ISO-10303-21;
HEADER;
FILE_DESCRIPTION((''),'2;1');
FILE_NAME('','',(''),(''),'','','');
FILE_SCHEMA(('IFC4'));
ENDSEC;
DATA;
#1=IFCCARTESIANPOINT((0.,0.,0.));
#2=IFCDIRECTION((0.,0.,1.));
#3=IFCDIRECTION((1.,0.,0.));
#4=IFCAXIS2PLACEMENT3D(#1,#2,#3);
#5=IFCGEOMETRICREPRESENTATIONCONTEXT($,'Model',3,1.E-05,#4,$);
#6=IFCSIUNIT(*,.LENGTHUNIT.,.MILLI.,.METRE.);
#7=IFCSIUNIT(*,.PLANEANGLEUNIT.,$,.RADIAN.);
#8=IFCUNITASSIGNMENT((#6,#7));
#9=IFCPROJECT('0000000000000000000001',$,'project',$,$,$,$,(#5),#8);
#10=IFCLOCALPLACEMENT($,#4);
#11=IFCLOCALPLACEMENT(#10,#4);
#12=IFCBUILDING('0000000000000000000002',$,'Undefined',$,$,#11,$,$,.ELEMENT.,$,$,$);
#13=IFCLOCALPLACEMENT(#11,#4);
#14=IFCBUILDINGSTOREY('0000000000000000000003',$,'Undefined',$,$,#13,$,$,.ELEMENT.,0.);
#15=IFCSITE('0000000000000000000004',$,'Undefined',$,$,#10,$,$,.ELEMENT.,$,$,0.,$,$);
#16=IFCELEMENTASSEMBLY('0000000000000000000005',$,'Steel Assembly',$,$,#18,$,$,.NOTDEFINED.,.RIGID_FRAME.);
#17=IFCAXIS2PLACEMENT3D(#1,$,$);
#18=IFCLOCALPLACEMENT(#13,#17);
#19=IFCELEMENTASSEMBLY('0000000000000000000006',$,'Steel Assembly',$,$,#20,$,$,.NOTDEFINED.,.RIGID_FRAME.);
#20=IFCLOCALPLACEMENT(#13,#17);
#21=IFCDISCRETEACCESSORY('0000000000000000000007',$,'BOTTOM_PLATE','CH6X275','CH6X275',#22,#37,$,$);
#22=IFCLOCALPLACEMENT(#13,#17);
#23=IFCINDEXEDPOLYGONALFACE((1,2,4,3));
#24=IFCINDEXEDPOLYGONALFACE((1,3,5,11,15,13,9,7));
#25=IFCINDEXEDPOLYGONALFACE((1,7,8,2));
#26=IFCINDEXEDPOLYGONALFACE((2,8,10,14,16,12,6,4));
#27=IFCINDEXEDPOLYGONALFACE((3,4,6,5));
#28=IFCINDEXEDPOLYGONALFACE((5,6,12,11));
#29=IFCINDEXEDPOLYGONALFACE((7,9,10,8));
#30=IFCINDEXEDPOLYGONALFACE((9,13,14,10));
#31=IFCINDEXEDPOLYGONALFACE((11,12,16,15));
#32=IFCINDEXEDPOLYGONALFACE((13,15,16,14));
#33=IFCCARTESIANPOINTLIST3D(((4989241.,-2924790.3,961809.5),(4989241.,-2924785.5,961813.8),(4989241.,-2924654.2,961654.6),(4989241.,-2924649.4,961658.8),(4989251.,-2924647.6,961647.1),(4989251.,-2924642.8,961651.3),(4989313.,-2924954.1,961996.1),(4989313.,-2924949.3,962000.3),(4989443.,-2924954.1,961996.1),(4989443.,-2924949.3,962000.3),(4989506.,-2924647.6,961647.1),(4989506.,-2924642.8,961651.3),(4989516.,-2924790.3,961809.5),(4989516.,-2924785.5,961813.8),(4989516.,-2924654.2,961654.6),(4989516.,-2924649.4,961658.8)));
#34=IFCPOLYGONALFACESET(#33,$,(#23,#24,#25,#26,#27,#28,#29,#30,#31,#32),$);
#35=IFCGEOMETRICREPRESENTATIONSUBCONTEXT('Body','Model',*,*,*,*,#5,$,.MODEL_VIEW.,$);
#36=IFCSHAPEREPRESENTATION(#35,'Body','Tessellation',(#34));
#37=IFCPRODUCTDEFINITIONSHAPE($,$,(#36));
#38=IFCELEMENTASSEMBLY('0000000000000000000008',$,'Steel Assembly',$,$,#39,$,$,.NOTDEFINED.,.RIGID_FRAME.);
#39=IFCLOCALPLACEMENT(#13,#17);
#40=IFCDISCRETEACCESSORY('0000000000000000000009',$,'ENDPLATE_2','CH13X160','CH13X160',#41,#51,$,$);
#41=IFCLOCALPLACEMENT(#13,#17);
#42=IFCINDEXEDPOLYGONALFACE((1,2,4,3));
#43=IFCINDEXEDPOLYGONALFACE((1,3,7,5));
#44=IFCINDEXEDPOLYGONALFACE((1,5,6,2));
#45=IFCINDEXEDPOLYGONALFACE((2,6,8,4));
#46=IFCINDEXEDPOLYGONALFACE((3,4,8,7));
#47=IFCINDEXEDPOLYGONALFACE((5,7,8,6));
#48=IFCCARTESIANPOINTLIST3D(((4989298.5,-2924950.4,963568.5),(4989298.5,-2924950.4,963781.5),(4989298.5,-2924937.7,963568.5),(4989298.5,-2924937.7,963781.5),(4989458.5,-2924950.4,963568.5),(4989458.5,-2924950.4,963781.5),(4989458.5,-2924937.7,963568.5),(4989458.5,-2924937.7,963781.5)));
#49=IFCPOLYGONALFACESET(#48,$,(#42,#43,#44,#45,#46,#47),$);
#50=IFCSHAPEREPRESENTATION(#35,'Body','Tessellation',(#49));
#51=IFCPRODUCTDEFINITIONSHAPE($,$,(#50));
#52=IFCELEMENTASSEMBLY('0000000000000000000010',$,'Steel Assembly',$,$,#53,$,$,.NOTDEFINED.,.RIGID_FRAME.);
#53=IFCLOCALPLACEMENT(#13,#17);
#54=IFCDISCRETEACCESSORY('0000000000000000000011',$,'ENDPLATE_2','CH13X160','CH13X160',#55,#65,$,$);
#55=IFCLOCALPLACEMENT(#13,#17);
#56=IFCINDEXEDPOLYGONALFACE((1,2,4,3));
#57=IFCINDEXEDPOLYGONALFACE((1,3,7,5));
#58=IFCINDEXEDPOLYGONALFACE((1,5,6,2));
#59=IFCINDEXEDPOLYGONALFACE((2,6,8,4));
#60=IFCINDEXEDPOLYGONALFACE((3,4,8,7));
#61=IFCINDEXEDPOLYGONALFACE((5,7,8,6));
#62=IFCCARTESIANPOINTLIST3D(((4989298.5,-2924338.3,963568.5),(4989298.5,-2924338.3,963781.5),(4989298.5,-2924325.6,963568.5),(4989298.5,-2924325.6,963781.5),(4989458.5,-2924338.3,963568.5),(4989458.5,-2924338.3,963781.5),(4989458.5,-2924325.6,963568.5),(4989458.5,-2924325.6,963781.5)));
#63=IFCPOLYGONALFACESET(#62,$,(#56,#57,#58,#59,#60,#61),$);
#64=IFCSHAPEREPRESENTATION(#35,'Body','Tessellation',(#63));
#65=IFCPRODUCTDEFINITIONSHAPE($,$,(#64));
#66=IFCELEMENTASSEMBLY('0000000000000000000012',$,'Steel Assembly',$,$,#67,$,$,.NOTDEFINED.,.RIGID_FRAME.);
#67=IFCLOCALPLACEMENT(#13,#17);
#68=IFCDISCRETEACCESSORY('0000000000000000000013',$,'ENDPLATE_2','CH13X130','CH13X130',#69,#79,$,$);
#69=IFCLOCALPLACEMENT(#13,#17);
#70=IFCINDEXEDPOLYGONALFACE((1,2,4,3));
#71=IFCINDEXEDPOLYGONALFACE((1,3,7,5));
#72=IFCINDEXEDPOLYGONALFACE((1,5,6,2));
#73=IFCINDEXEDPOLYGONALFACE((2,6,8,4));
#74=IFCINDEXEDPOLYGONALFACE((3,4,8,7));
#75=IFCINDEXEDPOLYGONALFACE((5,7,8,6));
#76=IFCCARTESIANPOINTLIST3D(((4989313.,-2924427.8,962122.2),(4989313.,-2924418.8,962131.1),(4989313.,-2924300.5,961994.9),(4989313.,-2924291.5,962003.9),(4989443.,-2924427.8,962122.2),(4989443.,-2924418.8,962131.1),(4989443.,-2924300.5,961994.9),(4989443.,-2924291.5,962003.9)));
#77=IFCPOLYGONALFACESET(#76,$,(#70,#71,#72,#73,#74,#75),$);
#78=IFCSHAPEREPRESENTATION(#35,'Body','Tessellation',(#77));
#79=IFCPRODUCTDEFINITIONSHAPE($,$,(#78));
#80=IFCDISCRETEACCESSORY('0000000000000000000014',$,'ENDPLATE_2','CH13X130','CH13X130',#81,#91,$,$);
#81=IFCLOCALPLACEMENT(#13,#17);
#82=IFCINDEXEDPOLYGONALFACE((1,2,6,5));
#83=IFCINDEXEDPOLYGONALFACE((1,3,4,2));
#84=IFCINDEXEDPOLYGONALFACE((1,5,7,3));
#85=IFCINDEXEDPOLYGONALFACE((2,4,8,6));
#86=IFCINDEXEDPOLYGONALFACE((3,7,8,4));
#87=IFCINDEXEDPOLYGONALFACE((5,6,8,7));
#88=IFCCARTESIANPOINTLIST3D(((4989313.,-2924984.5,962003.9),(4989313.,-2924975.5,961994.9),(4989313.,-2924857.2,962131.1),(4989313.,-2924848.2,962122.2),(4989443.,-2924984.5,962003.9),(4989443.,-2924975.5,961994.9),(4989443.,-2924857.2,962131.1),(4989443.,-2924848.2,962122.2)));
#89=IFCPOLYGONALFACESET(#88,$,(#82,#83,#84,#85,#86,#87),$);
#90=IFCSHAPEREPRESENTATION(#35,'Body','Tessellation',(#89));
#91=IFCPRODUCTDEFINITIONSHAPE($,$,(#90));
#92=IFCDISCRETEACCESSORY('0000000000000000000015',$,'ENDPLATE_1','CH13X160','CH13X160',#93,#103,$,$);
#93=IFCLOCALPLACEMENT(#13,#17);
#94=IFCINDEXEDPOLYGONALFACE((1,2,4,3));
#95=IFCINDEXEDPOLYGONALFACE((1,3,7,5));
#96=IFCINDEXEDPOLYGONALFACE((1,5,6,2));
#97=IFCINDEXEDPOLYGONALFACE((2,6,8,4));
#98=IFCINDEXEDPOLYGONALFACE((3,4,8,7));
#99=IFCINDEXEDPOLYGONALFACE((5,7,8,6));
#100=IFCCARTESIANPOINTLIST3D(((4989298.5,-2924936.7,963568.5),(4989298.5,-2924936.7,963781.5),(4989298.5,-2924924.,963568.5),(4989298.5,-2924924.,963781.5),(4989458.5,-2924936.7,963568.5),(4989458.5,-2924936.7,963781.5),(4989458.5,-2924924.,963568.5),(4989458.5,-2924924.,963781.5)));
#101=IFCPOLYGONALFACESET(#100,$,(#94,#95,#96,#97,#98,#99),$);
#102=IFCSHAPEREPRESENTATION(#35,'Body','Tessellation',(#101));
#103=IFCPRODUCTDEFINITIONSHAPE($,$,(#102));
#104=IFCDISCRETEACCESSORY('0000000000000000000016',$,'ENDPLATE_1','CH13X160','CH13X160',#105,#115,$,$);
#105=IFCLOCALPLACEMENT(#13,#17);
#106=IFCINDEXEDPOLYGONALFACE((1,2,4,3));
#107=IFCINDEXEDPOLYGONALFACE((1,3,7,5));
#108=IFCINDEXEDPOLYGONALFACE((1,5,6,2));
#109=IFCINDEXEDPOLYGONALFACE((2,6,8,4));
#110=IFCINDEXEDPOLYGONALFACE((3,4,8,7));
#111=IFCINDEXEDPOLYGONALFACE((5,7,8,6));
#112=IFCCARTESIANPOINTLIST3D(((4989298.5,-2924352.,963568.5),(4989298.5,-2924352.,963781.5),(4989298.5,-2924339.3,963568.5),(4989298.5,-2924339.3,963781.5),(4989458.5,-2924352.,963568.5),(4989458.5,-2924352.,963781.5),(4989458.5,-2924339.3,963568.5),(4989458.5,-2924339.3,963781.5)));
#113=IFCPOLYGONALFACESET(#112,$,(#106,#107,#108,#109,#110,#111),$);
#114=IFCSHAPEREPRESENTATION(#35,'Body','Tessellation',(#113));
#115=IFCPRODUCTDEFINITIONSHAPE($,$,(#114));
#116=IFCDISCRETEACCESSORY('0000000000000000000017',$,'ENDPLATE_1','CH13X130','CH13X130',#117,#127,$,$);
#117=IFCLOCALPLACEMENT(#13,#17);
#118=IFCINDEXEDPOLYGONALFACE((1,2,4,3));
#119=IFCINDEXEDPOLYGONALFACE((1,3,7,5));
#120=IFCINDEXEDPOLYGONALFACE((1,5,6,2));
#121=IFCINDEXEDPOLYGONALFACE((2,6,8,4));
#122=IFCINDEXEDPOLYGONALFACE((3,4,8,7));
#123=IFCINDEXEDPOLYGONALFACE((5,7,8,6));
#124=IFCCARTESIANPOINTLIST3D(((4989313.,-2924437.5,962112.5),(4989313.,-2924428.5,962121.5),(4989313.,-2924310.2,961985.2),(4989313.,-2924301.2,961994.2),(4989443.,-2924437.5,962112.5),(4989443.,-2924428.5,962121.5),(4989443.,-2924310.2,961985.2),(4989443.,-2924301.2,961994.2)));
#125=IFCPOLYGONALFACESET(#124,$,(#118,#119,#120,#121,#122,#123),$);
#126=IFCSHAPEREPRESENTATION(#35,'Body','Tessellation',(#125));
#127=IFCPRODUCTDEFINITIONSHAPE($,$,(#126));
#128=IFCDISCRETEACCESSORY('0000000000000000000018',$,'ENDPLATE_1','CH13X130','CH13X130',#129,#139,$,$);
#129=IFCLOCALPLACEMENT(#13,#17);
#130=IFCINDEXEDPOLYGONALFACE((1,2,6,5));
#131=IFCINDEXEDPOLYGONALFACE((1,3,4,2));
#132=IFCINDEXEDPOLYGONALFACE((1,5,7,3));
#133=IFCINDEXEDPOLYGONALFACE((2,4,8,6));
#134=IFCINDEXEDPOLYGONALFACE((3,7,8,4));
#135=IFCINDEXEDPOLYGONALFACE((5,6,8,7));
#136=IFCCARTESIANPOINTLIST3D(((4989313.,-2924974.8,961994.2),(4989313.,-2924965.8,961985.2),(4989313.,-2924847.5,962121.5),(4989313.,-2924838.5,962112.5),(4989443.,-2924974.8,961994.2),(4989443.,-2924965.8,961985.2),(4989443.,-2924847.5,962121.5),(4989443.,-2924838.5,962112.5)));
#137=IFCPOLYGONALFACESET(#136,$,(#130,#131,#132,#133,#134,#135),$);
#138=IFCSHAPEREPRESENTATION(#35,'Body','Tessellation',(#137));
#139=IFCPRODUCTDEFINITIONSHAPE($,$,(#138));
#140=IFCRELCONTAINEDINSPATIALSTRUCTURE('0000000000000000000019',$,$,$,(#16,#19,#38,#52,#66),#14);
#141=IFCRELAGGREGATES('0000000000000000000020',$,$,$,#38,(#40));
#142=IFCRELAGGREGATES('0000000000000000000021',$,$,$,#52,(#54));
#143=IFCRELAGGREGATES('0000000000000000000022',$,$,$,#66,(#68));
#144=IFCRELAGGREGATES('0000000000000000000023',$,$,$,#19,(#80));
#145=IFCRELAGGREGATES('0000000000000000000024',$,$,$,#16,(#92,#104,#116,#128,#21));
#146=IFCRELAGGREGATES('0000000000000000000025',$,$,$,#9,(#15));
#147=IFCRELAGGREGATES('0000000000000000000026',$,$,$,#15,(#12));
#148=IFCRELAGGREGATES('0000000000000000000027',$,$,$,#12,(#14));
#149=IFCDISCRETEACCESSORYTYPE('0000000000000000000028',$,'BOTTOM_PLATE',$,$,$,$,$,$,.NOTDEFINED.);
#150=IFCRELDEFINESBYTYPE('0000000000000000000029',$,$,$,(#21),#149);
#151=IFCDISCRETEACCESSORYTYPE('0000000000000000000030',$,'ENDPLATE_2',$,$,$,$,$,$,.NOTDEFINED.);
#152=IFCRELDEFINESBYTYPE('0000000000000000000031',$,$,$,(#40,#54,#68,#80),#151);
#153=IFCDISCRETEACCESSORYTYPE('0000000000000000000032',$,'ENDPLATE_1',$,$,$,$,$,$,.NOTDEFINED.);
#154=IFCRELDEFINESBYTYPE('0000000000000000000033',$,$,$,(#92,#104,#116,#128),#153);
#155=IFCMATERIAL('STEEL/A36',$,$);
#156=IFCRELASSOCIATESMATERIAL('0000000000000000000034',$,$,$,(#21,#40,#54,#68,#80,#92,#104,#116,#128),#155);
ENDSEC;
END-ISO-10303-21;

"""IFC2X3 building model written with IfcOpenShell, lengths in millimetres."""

from ifc_helpers import new_model, si_unit, frame, origin_with_axes, place, context, subcontext, project, spatial, polyline, outline, extrude, material, type_object, element, aggregate, save


model = new_model("IFC2X3")

# Units and contexts
model_context = context("Model", 3, precision=1e-05, world=origin_with_axes())
body_context = subcontext(model_context, "Body", "Model", "MODEL_VIEW")
ifc_project = project(units=[si_unit("LENGTHUNIT", "METRE", prefix="MILLI"), si_unit("PLANEANGLEUNIT", "RADIAN")], contexts=[model_context])

# Site, building, storey
site_placement = place(None, origin_with_axes())
site = spatial("IfcSite", under=ifc_project, at=site_placement, Name="Undefined", CompositionType="ELEMENT", RefElevation=0.0)
building_placement = place(site_placement, origin_with_axes())
building = spatial("IfcBuilding", under=site, at=building_placement, Name="Undefined", CompositionType="ELEMENT")
storey_placement = place(building_placement, origin_with_axes())
storey = spatial("IfcBuildingStorey", under=building, at=storey_placement, Name="Undefined", CompositionType="ELEMENT", Elevation=0.0)

# Element assembly
assembly_1_placement = place(storey_placement, origin_with_axes())
assembly_1 = element("IfcElementAssembly", 1, at=assembly_1_placement, inside=storey, Name="Steel Assembly", AssemblyPlace="NOTDEFINED", PredefinedType="RIGID_FRAME")

# Element assembly
assembly_2_placement = place(storey_placement, origin_with_axes())
assembly_2 = element("IfcElementAssembly", 2, at=assembly_2_placement, inside=storey, Name="Steel Assembly", AssemblyPlace="NOTDEFINED", PredefinedType="RIGID_FRAME")

# Discrete accessory
ifc_material_1 = material(Name="STEEL/A36")
discrete_accessory_type_1 = type_object("IfcDiscreteAccessoryType", Name="BOTTOM_PLATE")
discrete_accessory_1_placement = place(assembly_1_placement, frame((4989516.0, -2924787.9, 961811.6), z_axis=(0.0, 0.75135, 0.659903), x_axis=(0.0, 0.659903, -0.75135)))
discrete_accessory_1 = element("IfcDiscreteAccessory", 3, at=discrete_accessory_1_placement, type_object=discrete_accessory_type_1, material=ifc_material_1, Name="BOTTOM_PLATE", Description="CH6X275", ObjectType="CH6X275", context=body_context, shape_type="SweptSolid", body=[
    extrude(outline(polyline([(0.0, 0.0), (206.2, 0.0), (216.2, 10.0), (216.2, 265.0), (206.2, 275.0), (0.0, 275.0), (-248.3, 203.0), (-248.3, 73.0), (0.0, 0.0)])), frame((0.0, 0.0, -3.2), z_axis=(0.0, 0.0, 1.0), x_axis=(1.0, 0.0, 0.0)), (0.0, 0.0, 1.0), 6.4),
])

# Element assemblies, discrete accessories
assembly_3_placement = place(storey_placement, origin_with_axes())
assembly_3 = element("IfcElementAssembly", 4, at=assembly_3_placement, inside=storey, Name="Steel Assembly", AssemblyPlace="NOTDEFINED", PredefinedType="RIGID_FRAME")
discrete_accessory_type_2 = type_object("IfcDiscreteAccessoryType", Name="ENDPLATE_2")
discrete_accessory_2_placement = place(assembly_3_placement, frame((4989458.5, -2924944.1, 963568.5), z_axis=(0.0, -1.0, 0.0), x_axis=(0.0, 0.0, 1.0)))
discrete_accessory_2 = element("IfcDiscreteAccessory", 5, at=discrete_accessory_2_placement, type_object=discrete_accessory_type_2, material=ifc_material_1, Name="ENDPLATE_2", Description="CH13X160", ObjectType="CH13X160", context=body_context, shape_type="SweptSolid", body=[
    extrude(outline(polyline([(0.0, 0.0), (213.0, 0.0), (213.0, 160.0), (0.0, 160.0), (0.0, 0.0)])), frame((0.0, 0.0, -6.3), z_axis=(0.0, 0.0, 1.0), x_axis=(1.0, 0.0, 0.0)), (0.0, 0.0, 1.0), 12.7),
])
aggregate(assembly_3, [discrete_accessory_2])
assembly_4_placement = place(storey_placement, origin_with_axes())
assembly_4 = element("IfcElementAssembly", 6, at=assembly_4_placement, inside=storey, Name="Steel Assembly", AssemblyPlace="NOTDEFINED", PredefinedType="RIGID_FRAME")
discrete_accessory_3_placement = place(assembly_4_placement, frame((4989298.5, -2924332.0, 963568.5), z_axis=(0.0, 1.0, 0.0), x_axis=(0.0, 0.0, 1.0)))
discrete_accessory_3 = element("IfcDiscreteAccessory", 7, at=discrete_accessory_3_placement, type_object=discrete_accessory_type_2, material=ifc_material_1, Name="ENDPLATE_2", Description="CH13X160", ObjectType="CH13X160", context=body_context, shape_type="SweptSolid", body=[
    extrude(outline(polyline([(0.0, 0.0), (213.0, 0.0), (213.0, 160.0), (0.0, 160.0), (0.0, 0.0)])), frame((0.0, 0.0, -6.3), z_axis=(0.0, 0.0, 1.0), x_axis=(1.0, 0.0, 0.0)), (0.0, 0.0, 1.0), 12.7),
])
aggregate(assembly_4, [discrete_accessory_3])
assembly_5_placement = place(storey_placement, origin_with_axes())
assembly_5 = element("IfcElementAssembly", 8, at=assembly_5_placement, inside=storey, Name="Steel Assembly", AssemblyPlace="NOTDEFINED", PredefinedType="RIGID_FRAME")
discrete_accessory_4_placement = place(assembly_5_placement, frame((4989443.0, -2924296.0, 961999.4), z_axis=(0.0, -0.707107, -0.707107), x_axis=(0.0, -0.707107, 0.707107)))
discrete_accessory_4 = element("IfcDiscreteAccessory", 9, at=discrete_accessory_4_placement, type_object=discrete_accessory_type_2, material=ifc_material_1, Name="ENDPLATE_2", Description="CH13X130", ObjectType="CH13X130", context=body_context, shape_type="SweptSolid", body=[
    extrude(outline(polyline([(0.0, 0.0), (180.0, 0.0), (180.0, 130.0), (0.0, 130.0), (0.0, 0.0)])), frame((0.0, 0.0, -6.3), z_axis=(0.0, 0.0, 1.0), x_axis=(1.0, 0.0, 0.0)), (0.0, 0.0, 1.0), 12.7),
])
aggregate(assembly_5, [discrete_accessory_4])

# Discrete accessories
discrete_accessory_5_placement = place(assembly_2_placement, frame((4989443.0, -2924980.0, 961999.4), z_axis=(0.0, -0.707107, 0.707107), x_axis=(0.0, 0.707107, 0.707107)))
discrete_accessory_5 = element("IfcDiscreteAccessory", 10, at=discrete_accessory_5_placement, type_object=discrete_accessory_type_2, material=ifc_material_1, Name="ENDPLATE_2", Description="CH13X130", ObjectType="CH13X130", context=body_context, shape_type="SweptSolid", body=[
    extrude(outline(polyline([(0.0, 0.0), (180.0, 0.0), (180.0, 130.0), (0.0, 130.0), (0.0, 0.0)])), frame((0.0, 0.0, -6.3), z_axis=(0.0, 0.0, 1.0), x_axis=(1.0, 0.0, 0.0)), (0.0, 0.0, 1.0), 12.7),
])
aggregate(assembly_2, [discrete_accessory_5])
discrete_accessory_type_3 = type_object("IfcDiscreteAccessoryType", Name="ENDPLATE_1")
discrete_accessory_6_placement = place(assembly_1_placement, frame((4989458.5, -2924930.4, 963568.5), z_axis=(0.0, -1.0, 0.0), x_axis=(0.0, 0.0, 1.0)))
discrete_accessory_6 = element("IfcDiscreteAccessory", 11, at=discrete_accessory_6_placement, type_object=discrete_accessory_type_3, material=ifc_material_1, Name="ENDPLATE_1", Description="CH13X160", ObjectType="CH13X160", context=body_context, shape_type="SweptSolid", body=[
    extrude(outline(polyline([(0.0, 0.0), (213.0, 0.0), (213.0, 160.0), (0.0, 160.0), (0.0, 0.0)])), frame((0.0, 0.0, -6.3), z_axis=(0.0, 0.0, 1.0), x_axis=(1.0, 0.0, 0.0)), (0.0, 0.0, 1.0), 12.7),
])
discrete_accessory_7_placement = place(assembly_1_placement, frame((4989298.5, -2924345.7, 963568.5), z_axis=(0.0, 1.0, 0.0), x_axis=(0.0, 0.0, 1.0)))
discrete_accessory_7 = element("IfcDiscreteAccessory", 12, at=discrete_accessory_7_placement, type_object=discrete_accessory_type_3, material=ifc_material_1, Name="ENDPLATE_1", Description="CH13X160", ObjectType="CH13X160", context=body_context, shape_type="SweptSolid", body=[
    extrude(outline(polyline([(0.0, 0.0), (213.0, 0.0), (213.0, 160.0), (0.0, 160.0), (0.0, 0.0)])), frame((0.0, 0.0, -6.3), z_axis=(0.0, 0.0, 1.0), x_axis=(1.0, 0.0, 0.0)), (0.0, 0.0, 1.0), 12.7),
])
discrete_accessory_8_placement = place(assembly_1_placement, frame((4989443.0, -2924305.7, 961989.7), z_axis=(0.0, -0.707107, -0.707107), x_axis=(0.0, -0.707107, 0.707107)))
discrete_accessory_8 = element("IfcDiscreteAccessory", 13, at=discrete_accessory_8_placement, type_object=discrete_accessory_type_3, material=ifc_material_1, Name="ENDPLATE_1", Description="CH13X130", ObjectType="CH13X130", context=body_context, shape_type="SweptSolid", body=[
    extrude(outline(polyline([(0.0, 0.0), (180.0, 0.0), (180.0, 130.0), (0.0, 130.0), (0.0, 0.0)])), frame((0.0, 0.0, -6.3), z_axis=(0.0, 0.0, 1.0), x_axis=(1.0, 0.0, 0.0)), (0.0, 0.0, 1.0), 12.7),
])
discrete_accessory_9_placement = place(assembly_1_placement, frame((4989443.0, -2924970.3, 961989.7), z_axis=(0.0, -0.707107, 0.707107), x_axis=(0.0, 0.707107, 0.707107)))
discrete_accessory_9 = element("IfcDiscreteAccessory", 14, at=discrete_accessory_9_placement, type_object=discrete_accessory_type_3, material=ifc_material_1, Name="ENDPLATE_1", Description="CH13X130", ObjectType="CH13X130", context=body_context, shape_type="SweptSolid", body=[
    extrude(outline(polyline([(0.0, 0.0), (180.0, 0.0), (180.0, 130.0), (0.0, 130.0), (0.0, 0.0)])), frame((0.0, 0.0, -6.3), z_axis=(0.0, 0.0, 1.0), x_axis=(1.0, 0.0, 0.0)), (0.0, 0.0, 1.0), 12.7),
])
aggregate(assembly_1, [discrete_accessory_6, discrete_accessory_7, discrete_accessory_8, discrete_accessory_9, discrete_accessory_1])

save(model, "model.ifc")
